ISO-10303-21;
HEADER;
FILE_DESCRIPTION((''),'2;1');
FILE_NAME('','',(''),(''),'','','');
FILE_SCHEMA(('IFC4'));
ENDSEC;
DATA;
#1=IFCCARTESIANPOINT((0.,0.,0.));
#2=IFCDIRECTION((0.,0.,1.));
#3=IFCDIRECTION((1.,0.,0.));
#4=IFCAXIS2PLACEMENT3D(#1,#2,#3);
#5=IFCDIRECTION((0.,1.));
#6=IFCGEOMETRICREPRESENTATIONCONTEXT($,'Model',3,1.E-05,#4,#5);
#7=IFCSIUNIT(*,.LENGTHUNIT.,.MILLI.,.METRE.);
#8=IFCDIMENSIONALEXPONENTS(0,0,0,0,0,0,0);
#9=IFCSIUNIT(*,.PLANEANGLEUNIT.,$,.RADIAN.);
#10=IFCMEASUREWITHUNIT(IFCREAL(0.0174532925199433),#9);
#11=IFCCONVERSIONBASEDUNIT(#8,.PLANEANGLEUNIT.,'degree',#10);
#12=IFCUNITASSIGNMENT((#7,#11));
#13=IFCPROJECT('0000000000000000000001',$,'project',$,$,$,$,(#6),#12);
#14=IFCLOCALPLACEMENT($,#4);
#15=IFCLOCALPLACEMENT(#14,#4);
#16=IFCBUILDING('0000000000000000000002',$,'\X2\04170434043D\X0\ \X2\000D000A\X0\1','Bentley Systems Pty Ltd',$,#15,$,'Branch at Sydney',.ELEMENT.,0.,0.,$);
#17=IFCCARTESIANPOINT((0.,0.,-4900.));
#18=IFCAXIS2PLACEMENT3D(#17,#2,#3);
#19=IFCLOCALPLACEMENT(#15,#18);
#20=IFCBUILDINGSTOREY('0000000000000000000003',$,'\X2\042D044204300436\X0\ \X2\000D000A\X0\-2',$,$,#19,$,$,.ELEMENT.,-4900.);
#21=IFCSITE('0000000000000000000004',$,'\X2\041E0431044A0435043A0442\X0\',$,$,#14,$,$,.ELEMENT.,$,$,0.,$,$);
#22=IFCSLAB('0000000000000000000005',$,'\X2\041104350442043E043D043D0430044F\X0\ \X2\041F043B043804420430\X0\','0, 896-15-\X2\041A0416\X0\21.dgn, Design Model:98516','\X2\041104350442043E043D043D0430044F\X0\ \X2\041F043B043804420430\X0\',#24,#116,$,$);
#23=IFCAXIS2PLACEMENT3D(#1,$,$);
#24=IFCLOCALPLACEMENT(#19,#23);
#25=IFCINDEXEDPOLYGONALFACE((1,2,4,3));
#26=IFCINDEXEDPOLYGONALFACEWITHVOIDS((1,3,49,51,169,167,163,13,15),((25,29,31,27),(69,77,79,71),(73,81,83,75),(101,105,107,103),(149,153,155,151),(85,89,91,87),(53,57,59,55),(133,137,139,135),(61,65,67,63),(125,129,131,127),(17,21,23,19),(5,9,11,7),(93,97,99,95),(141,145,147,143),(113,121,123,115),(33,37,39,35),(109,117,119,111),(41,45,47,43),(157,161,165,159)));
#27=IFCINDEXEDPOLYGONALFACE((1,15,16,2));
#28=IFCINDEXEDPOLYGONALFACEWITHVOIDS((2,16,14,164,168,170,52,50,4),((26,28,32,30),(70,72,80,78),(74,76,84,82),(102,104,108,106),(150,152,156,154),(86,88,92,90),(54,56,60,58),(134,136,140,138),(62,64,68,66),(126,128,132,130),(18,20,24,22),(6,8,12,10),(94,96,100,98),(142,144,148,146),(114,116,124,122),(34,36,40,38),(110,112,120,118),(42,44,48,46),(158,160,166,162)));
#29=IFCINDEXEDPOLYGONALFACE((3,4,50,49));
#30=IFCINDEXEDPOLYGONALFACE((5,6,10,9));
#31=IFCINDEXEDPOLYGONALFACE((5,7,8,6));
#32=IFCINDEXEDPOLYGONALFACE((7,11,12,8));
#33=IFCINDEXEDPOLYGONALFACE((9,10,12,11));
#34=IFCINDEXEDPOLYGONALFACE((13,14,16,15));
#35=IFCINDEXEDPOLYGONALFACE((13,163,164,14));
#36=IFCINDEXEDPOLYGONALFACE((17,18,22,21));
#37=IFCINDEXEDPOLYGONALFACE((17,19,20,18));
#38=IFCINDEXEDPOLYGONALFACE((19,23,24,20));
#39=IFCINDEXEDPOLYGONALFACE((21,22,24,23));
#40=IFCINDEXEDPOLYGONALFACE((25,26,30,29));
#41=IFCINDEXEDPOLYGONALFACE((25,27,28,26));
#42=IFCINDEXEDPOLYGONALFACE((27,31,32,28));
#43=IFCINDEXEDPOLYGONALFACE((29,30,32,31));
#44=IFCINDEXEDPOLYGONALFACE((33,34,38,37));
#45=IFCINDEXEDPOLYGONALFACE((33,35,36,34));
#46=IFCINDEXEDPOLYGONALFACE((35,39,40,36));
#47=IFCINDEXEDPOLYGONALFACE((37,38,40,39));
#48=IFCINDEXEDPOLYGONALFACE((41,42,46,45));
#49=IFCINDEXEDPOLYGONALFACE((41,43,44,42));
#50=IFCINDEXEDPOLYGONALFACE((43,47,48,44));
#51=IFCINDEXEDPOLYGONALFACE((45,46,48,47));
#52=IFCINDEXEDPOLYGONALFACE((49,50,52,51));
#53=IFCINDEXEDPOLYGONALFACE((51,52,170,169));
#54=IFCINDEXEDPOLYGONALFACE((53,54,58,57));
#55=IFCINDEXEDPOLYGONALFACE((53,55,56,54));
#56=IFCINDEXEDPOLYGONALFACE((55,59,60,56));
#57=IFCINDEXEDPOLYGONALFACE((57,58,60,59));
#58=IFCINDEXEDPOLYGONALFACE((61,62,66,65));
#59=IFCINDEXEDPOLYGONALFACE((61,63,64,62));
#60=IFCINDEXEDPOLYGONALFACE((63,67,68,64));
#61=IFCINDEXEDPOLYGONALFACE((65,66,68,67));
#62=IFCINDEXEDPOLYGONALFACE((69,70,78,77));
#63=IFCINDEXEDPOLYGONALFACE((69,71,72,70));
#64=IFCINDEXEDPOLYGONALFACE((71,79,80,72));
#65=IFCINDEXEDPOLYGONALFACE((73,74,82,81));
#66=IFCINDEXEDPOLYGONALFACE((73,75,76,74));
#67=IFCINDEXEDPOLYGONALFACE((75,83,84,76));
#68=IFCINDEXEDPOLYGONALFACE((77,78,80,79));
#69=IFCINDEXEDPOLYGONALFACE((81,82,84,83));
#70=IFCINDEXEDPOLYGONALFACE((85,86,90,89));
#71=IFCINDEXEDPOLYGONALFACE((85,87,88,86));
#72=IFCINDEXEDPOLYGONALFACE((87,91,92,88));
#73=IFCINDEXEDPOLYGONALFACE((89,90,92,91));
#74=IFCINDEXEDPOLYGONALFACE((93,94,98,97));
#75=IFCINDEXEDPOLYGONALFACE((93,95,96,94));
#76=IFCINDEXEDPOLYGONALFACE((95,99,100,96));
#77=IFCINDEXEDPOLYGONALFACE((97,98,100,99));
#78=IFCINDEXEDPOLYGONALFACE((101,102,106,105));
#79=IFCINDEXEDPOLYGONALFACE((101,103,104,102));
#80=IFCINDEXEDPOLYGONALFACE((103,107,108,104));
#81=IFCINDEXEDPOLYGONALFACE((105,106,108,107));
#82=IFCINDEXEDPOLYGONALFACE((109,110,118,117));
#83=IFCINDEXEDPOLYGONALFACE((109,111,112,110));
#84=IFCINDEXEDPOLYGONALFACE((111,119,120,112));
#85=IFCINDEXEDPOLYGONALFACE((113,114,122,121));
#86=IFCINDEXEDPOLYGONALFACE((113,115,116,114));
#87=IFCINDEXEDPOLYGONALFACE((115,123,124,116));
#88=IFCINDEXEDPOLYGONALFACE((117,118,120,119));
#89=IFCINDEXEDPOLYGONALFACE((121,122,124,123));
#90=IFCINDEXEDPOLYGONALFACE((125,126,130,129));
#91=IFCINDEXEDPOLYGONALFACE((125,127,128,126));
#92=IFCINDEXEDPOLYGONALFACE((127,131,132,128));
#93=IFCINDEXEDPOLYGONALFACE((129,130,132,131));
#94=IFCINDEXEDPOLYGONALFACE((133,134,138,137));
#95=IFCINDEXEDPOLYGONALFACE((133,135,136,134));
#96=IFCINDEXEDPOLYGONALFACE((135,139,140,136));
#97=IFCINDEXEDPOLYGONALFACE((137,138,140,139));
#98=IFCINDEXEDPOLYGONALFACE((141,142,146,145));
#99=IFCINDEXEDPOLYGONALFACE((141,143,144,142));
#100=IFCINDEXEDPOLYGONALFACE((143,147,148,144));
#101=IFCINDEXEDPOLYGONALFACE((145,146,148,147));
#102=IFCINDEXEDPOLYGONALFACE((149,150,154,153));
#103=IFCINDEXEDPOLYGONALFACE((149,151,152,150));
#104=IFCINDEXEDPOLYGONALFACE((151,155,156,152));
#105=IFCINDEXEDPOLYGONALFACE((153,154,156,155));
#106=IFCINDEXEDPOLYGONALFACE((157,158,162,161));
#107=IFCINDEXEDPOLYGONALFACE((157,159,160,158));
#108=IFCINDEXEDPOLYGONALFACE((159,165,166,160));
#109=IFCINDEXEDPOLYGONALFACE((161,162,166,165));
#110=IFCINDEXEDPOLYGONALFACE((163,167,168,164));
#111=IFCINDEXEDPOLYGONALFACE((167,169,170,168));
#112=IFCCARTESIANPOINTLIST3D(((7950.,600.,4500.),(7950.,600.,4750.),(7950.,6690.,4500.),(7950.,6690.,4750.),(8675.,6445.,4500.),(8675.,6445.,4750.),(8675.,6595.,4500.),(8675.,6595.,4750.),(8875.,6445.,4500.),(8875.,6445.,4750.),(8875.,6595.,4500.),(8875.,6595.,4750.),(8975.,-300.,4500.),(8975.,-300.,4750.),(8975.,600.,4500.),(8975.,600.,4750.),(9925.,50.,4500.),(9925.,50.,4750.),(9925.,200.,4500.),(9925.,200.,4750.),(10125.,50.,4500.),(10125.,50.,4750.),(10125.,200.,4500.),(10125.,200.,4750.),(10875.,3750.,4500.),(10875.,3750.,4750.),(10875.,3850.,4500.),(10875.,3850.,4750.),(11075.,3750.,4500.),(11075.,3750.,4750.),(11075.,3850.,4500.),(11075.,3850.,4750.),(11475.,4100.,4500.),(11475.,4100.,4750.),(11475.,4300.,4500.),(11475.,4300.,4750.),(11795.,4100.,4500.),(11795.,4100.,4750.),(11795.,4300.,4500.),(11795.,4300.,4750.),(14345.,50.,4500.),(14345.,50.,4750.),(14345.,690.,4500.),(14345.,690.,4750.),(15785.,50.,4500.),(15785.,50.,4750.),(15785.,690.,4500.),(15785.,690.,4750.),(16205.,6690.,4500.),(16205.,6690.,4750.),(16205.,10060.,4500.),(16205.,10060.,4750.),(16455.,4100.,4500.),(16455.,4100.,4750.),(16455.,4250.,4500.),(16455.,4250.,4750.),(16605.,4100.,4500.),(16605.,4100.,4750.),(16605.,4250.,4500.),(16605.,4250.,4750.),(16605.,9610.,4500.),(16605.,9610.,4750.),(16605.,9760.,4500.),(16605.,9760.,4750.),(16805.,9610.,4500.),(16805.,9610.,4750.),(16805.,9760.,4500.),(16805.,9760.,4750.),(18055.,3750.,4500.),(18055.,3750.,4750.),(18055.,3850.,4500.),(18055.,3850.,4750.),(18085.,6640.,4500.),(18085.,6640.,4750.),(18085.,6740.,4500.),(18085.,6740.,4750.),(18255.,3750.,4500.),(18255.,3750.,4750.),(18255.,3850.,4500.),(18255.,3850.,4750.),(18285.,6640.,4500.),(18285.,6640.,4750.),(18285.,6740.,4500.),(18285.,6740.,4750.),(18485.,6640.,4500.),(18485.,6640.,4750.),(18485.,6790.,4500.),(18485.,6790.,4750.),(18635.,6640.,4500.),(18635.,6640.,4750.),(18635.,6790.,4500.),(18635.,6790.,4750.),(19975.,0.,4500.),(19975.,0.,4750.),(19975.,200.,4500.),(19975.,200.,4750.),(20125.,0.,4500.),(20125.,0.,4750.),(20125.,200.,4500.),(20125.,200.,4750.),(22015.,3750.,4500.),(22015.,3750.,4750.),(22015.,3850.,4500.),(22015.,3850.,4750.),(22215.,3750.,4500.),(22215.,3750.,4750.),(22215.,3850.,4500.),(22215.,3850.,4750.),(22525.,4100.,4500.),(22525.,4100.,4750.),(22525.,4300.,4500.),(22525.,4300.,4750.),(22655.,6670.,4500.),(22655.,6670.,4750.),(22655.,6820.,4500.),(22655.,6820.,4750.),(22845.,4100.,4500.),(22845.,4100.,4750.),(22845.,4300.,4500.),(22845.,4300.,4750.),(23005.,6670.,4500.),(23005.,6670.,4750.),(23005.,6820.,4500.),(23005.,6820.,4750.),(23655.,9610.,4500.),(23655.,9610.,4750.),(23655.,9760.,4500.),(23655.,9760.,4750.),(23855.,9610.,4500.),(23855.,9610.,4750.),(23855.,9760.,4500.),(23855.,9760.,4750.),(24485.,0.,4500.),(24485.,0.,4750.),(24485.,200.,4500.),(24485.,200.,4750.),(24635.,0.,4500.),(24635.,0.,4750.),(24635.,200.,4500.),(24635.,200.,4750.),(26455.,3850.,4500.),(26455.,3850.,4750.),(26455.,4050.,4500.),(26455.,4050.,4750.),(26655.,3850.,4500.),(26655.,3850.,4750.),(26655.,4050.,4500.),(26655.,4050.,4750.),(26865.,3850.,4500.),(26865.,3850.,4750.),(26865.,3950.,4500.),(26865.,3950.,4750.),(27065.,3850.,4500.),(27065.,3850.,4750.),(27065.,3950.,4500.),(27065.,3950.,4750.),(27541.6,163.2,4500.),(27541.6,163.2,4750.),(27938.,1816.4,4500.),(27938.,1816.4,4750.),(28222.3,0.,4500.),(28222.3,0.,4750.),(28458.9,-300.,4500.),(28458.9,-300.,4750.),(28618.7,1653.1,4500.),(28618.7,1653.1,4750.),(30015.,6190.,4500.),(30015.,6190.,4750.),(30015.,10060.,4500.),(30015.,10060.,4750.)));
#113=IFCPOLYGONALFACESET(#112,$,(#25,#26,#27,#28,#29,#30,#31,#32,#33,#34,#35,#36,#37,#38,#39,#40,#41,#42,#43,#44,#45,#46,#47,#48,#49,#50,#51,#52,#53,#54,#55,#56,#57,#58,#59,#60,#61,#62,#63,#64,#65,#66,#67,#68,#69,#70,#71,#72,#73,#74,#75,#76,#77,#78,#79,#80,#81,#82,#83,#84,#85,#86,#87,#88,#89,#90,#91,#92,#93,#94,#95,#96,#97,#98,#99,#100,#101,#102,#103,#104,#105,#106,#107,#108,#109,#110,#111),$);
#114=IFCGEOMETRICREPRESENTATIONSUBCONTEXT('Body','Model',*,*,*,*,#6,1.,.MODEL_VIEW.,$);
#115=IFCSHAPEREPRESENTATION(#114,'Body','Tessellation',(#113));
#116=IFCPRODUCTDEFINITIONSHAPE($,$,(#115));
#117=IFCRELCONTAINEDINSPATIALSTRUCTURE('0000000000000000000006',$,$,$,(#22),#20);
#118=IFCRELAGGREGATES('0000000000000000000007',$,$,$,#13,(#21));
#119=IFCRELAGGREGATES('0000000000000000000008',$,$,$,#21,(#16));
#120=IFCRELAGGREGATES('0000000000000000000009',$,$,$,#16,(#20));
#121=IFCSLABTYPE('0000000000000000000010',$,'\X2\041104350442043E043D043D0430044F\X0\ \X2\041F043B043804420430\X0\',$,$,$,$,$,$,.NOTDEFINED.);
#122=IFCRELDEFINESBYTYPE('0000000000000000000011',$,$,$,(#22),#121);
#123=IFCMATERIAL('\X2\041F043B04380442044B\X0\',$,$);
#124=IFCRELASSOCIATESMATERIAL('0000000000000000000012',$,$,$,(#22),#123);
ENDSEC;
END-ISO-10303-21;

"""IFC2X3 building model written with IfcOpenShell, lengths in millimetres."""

from ifc_helpers import new_model, entity, si_unit, converted_unit, direction, frame, frame_2d, origin_with_axes, place, context, subcontext, project, spatial, polyline, rectangle, outline, extrude, material, type_object, element, save


model = new_model("IFC2X3")

# Units and contexts
model_context = context("Model", 3, precision=1e-05, world=origin_with_axes(), true_north=direction((0.0, 1.0)))
body_context = subcontext(model_context, "Body", "Model", "MODEL_VIEW", scale=1.0)
ifc_project = project(units=[si_unit("LENGTHUNIT", "METRE", prefix="MILLI"), converted_unit("PLANEANGLEUNIT", "degree", entity("IfcReal", 0.0174532925199433), si_unit("PLANEANGLEUNIT", "RADIAN"), dimensions=[0, 0, 0, 0, 0, 0, 0])], contexts=[model_context])

# Site, building, storey
site_placement = place(None, origin_with_axes())
site = spatial("IfcSite", under=ifc_project, at=site_placement, Name="Объект", CompositionType="ELEMENT", RefElevation=0.0)
building_placement = place(site_placement, origin_with_axes())
building = spatial("IfcBuilding", under=site, at=building_placement, Name="Здн \r\n1", Description="Bentley Systems Pty Ltd", LongName="Branch at Sydney", CompositionType="ELEMENT", ElevationOfRefHeight=0.0, ElevationOfTerrain=0.0)
storey_placement = place(building_placement, frame((0.0, 0.0, -4900.0), z_axis=(0.0, 0.0, 1.0), x_axis=(1.0, 0.0, 0.0)))
storey = spatial("IfcBuildingStorey", under=building, at=storey_placement, Name="Этаж \r\n-2", CompositionType="ELEMENT", Elevation=-4900.0)

# Shared definitions
ifc_material_1 = material(Name="Плиты")
slab_type = type_object("IfcSlabType", Name="Бетонная Плита", PredefinedType="NOTDEFINED")

# Slab, openings
slab_1_placement = place(storey_placement, frame((7950.0, 6690.0, 4750.0), z_axis=(0.0, 0.0, -1.0), x_axis=(1.0, 0.0, 0.0)))
slab_1 = element("IfcSlab", 1, at=slab_1_placement, inside=storey, type_object=slab_type, material=ifc_material_1, Name="Бетонная Плита", Description="0, 896-15-КЖ21.dgn, Design Model:98516", ObjectType="Бетонная Плита", context=body_context, shape_type="SweptSolid", body=[
    extrude(outline(polyline([(0.0, 0.0), (8255.0, 0.0), (8255.0, -3370.0), (22065.0, -3370.0), (22065.0, 500.0), (20508.9, 6990.0), (1025.0, 6990.0), (1025.0, 6090.0), (0.0, 6090.0), (0.0, 0.0)])), origin_with_axes(), (0.0, 0.0, 1.0), 250.0),
])
opening_1_placement = place(slab_1_placement, frame((6395.0, 6000.0, 0.0), z_axis=(0.0, 0.0, 1.0), x_axis=(1.0, 0.0, 0.0)))
element("IfcOpeningElement", 2, at=opening_1_placement, cuts=slab_1, ObjectType="Opening", context=body_context, shape_type="SweptSolid", body=[
    extrude(rectangle(XDim=1440.0, YDim=640.0, at=frame_2d((-720.0, 320.0), x_axis=(1.0, 0.0))), frame((0.0, 0.0, 375.0), z_axis=(0.0, 0.0, -1.0), x_axis=(-1.0, 0.0, 0.0)), (0.0, 0.0, 1.0), 750.0),
])
opening_2_placement = place(slab_1_placement, frame((1975.0, 6490.0, 0.0), z_axis=(0.0, 0.0, 1.0), x_axis=(1.0, 0.0, 0.0)))
element("IfcOpeningElement", 3, at=opening_2_placement, cuts=slab_1, ObjectType="Opening", context=body_context, shape_type="SweptSolid", body=[
    extrude(rectangle(XDim=200.0, YDim=150.0, at=frame_2d((-100.0, 75.0), x_axis=(1.0, 0.0))), frame((0.0, 0.0, 375.0), z_axis=(0.0, 0.0, -1.0), x_axis=(-1.0, 0.0, 0.0)), (0.0, 0.0, 1.0), 750.0),
])
opening_3_placement = place(slab_1_placement, frame((725.0, 95.0, 0.0), z_axis=(0.0, 0.0, 1.0), x_axis=(1.0, 0.0, 0.0)))
element("IfcOpeningElement", 4, at=opening_3_placement, cuts=slab_1, ObjectType="Opening", context=body_context, shape_type="SweptSolid", body=[
    extrude(rectangle(XDim=200.0, YDim=150.0, at=frame_2d((-100.0, 75.0), x_axis=(1.0, 0.0))), frame((0.0, 0.0, 375.0), z_axis=(0.0, 0.0, -1.0), x_axis=(-1.0, 0.0, 0.0)), (0.0, 0.0, 1.0), 750.0),
])
opening_4_placement = place(slab_1_placement, frame((2925.0, 2840.0, 0.0), z_axis=(0.0, 0.0, 1.0), x_axis=(1.0, 0.0, 0.0)))
element("IfcOpeningElement", 5, at=opening_4_placement, cuts=slab_1, ObjectType="Opening", context=body_context, shape_type="SweptSolid", body=[
    extrude(rectangle(XDim=200.0, YDim=100.0, at=frame_2d((-100.0, 50.0), x_axis=(1.0, 0.0))), frame((0.0, 0.0, 375.0), z_axis=(0.0, 0.0, -1.0), x_axis=(-1.0, 0.0, 0.0)), (0.0, 0.0, 1.0), 750.0),
])
opening_5_placement = place(slab_1_placement, frame((3525.0, 2390.0, 0.0), z_axis=(0.0, 0.0, 1.0), x_axis=(1.0, 0.0, 0.0)))
element("IfcOpeningElement", 6, at=opening_5_placement, cuts=slab_1, ObjectType="Opening", context=body_context, shape_type="SweptSolid", body=[
    extrude(rectangle(XDim=320.0, YDim=200.0, at=frame_2d((-160.0, 100.0), x_axis=(1.0, 0.0))), frame((0.0, 0.0, 375.0), z_axis=(0.0, 0.0, -1.0), x_axis=(-1.0, 0.0, 0.0)), (0.0, 0.0, 1.0), 750.0),
])
opening_6_placement = place(slab_1_placement, frame((12025.0, 6490.0, 0.0), z_axis=(0.0, 0.0, 1.0), x_axis=(1.0, 0.0, 0.0)))
element("IfcOpeningElement", 7, at=opening_6_placement, cuts=slab_1, ObjectType="Opening", context=body_context, shape_type="SweptSolid", body=[
    extrude(rectangle(XDim=150.0, YDim=200.0, at=frame_2d((-75.0, 100.0), x_axis=(1.0, 0.0))), frame((0.0, 0.0, 375.0), z_axis=(0.0, 0.0, -1.0), x_axis=(-1.0, 0.0, 0.0)), (0.0, 0.0, 1.0), 750.0),
])
opening_7_placement = place(slab_1_placement, frame((16535.0, 6490.0, 0.0), z_axis=(0.0, 0.0, 1.0), x_axis=(1.0, 0.0, 0.0)))
element("IfcOpeningElement", 8, at=opening_7_placement, cuts=slab_1, ObjectType="Opening", context=body_context, shape_type="SweptSolid", body=[
    extrude(rectangle(XDim=150.0, YDim=200.0, at=frame_2d((-75.0, 100.0), x_axis=(1.0, 0.0))), frame((0.0, 0.0, 375.0), z_axis=(0.0, 0.0, -1.0), x_axis=(-1.0, 0.0, 0.0)), (0.0, 0.0, 1.0), 750.0),
])
opening_8_placement = place(slab_1_placement, frame((19591.6, 4873.6, 0.0), z_axis=(0.0, 0.0, 1.0), x_axis=(1.0, 0.0, 0.0)))
element("IfcOpeningElement", 9, at=opening_8_placement, cuts=slab_1, ObjectType="Opening", context=body_context, shape_type="SweptSolid", body=[
    extrude(rectangle(XDim=1700.0, YDim=700.0, at=frame_2d((-538.5, 908.2), x_axis=(0.233165, 0.972437))), frame((0.0, 0.0, 375.0), z_axis=(0.0, 0.0, -1.0), x_axis=(-1.0, 0.0, 0.0)), (0.0, 0.0, 1.0), 750.0),
])
opening_9_placement = place(slab_1_placement, frame((8655.0, -3070.0, 0.0), z_axis=(0.0, 0.0, 1.0), x_axis=(1.0, 0.0, 0.0)))
element("IfcOpeningElement", 10, at=opening_9_placement, cuts=slab_1, ObjectType="Opening", context=body_context, shape_type="SweptSolid", body=[
    extrude(rectangle(XDim=200.0, YDim=150.0, at=frame_2d((-100.0, 75.0), x_axis=(1.0, 0.0))), frame((0.0, 0.0, 375.0), z_axis=(0.0, 0.0, -1.0), x_axis=(-1.0, 0.0, 0.0)), (0.0, 0.0, 1.0), 750.0),
])
opening_10_placement = place(slab_1_placement, frame((15705.0, -3070.0, 0.0), z_axis=(0.0, 0.0, 1.0), x_axis=(1.0, 0.0, 0.0)))
element("IfcOpeningElement", 11, at=opening_10_placement, cuts=slab_1, ObjectType="Opening", context=body_context, shape_type="SweptSolid", body=[
    extrude(rectangle(XDim=200.0, YDim=150.0, at=frame_2d((-100.0, 75.0), x_axis=(1.0, 0.0))), frame((0.0, 0.0, 375.0), z_axis=(0.0, 0.0, -1.0), x_axis=(-1.0, 0.0, 0.0)), (0.0, 0.0, 1.0), 750.0),
])
opening_11_placement = place(slab_1_placement, frame((10135.0, -50.0, 0.0), z_axis=(0.0, 0.0, 1.0), x_axis=(1.0, 0.0, 0.0)))
element("IfcOpeningElement", 12, at=opening_11_placement, cuts=slab_1, ObjectType="Opening", context=body_context, shape_type="SweptSolid", body=[
    extrude(rectangle(XDim=200.0, YDim=100.0, at=frame_2d((-100.0, 50.0), x_axis=(1.0, 0.0))), frame((0.0, 0.0, 375.0), z_axis=(0.0, 0.0, -1.0), x_axis=(-1.0, 0.0, 0.0)), (0.0, 0.0, 1.0), 750.0),
])
opening_12_placement = place(slab_1_placement, frame((10535.0, -100.0, 0.0), z_axis=(0.0, 0.0, 1.0), x_axis=(1.0, 0.0, 0.0)))
element("IfcOpeningElement", 13, at=opening_12_placement, cuts=slab_1, ObjectType="Opening", context=body_context, shape_type="SweptSolid", body=[
    extrude(rectangle(XDim=150.0, YDim=150.0, at=frame_2d((-75.0, 75.0), x_axis=(1.0, 0.0))), frame((0.0, 0.0, 375.0), z_axis=(0.0, 0.0, -1.0), x_axis=(-1.0, 0.0, 0.0)), (0.0, 0.0, 1.0), 750.0),
])
opening_13_placement = place(slab_1_placement, frame((14705.0, -130.0, 0.0), z_axis=(0.0, 0.0, 1.0), x_axis=(1.0, 0.0, 0.0)))
element("IfcOpeningElement", 14, at=opening_13_placement, cuts=slab_1, ObjectType="Opening", context=body_context, shape_type="SweptSolid", body=[
    extrude(rectangle(XDim=350.0, YDim=150.0, at=frame_2d((-175.0, 75.0), x_axis=(1.0, 0.0))), frame((0.0, 0.0, 375.0), z_axis=(0.0, 0.0, -1.0), x_axis=(-1.0, 0.0, 0.0)), (0.0, 0.0, 1.0), 750.0),
])
opening_14_placement = place(slab_1_placement, frame((8505.0, 2440.0, 0.0), z_axis=(0.0, 0.0, 1.0), x_axis=(1.0, 0.0, 0.0)))
element("IfcOpeningElement", 15, at=opening_14_placement, cuts=slab_1, ObjectType="Opening", context=body_context, shape_type="SweptSolid", body=[
    extrude(rectangle(XDim=150.0, YDim=150.0, at=frame_2d((-75.0, 75.0), x_axis=(1.0, 0.0))), frame((0.0, 0.0, 375.0), z_axis=(0.0, 0.0, -1.0), x_axis=(-1.0, 0.0, 0.0)), (0.0, 0.0, 1.0), 750.0),
])
opening_15_placement = place(slab_1_placement, frame((10105.0, 2840.0, 0.0), z_axis=(0.0, 0.0, 1.0), x_axis=(1.0, 0.0, 0.0)))
element("IfcOpeningElement", 16, at=opening_15_placement, cuts=slab_1, ObjectType="Opening", context=body_context, shape_type="SweptSolid", body=[
    extrude(rectangle(XDim=200.0, YDim=100.0, at=frame_2d((-100.0, 50.0), x_axis=(1.0, 0.0))), frame((0.0, 0.0, 375.0), z_axis=(0.0, 0.0, -1.0), x_axis=(-1.0, 0.0, 0.0)), (0.0, 0.0, 1.0), 750.0),
])
opening_16_placement = place(slab_1_placement, frame((14065.0, 2840.0, 0.0), z_axis=(0.0, 0.0, 1.0), x_axis=(1.0, 0.0, 0.0)))
element("IfcOpeningElement", 17, at=opening_16_placement, cuts=slab_1, ObjectType="Opening", context=body_context, shape_type="SweptSolid", body=[
    extrude(rectangle(XDim=200.0, YDim=100.0, at=frame_2d((-100.0, 50.0), x_axis=(1.0, 0.0))), frame((0.0, 0.0, 375.0), z_axis=(0.0, 0.0, -1.0), x_axis=(-1.0, 0.0, 0.0)), (0.0, 0.0, 1.0), 750.0),
])
opening_17_placement = place(slab_1_placement, frame((14575.0, 2390.0, 0.0), z_axis=(0.0, 0.0, 1.0), x_axis=(1.0, 0.0, 0.0)))
element("IfcOpeningElement", 18, at=opening_17_placement, cuts=slab_1, ObjectType="Opening", context=body_context, shape_type="SweptSolid", body=[
    extrude(rectangle(XDim=320.0, YDim=200.0, at=frame_2d((-160.0, 100.0), x_axis=(1.0, 0.0))), frame((0.0, 0.0, 375.0), z_axis=(0.0, 0.0, -1.0), x_axis=(-1.0, 0.0, 0.0)), (0.0, 0.0, 1.0), 750.0),
])
opening_18_placement = place(slab_1_placement, frame((18505.0, 2640.0, 0.0), z_axis=(0.0, 0.0, 1.0), x_axis=(1.0, 0.0, 0.0)))
element("IfcOpeningElement", 19, at=opening_18_placement, cuts=slab_1, ObjectType="Opening", context=body_context, shape_type="SweptSolid", body=[
    extrude(rectangle(XDim=200.0, YDim=200.0, at=frame_2d((-100.0, 100.0), x_axis=(1.0, 0.0))), frame((0.0, 0.0, 375.0), z_axis=(0.0, 0.0, -1.0), x_axis=(-1.0, 0.0, 0.0)), (0.0, 0.0, 1.0), 750.0),
])
opening_19_placement = place(slab_1_placement, frame((18915.0, 2740.0, 0.0), z_axis=(0.0, 0.0, 1.0), x_axis=(1.0, 0.0, 0.0)))
element("IfcOpeningElement", 20, at=opening_19_placement, cuts=slab_1, ObjectType="Opening", context=body_context, shape_type="SweptSolid", body=[
    extrude(rectangle(XDim=200.0, YDim=100.0, at=frame_2d((-100.0, 50.0), x_axis=(1.0, 0.0))), frame((0.0, 0.0, 375.0), z_axis=(0.0, 0.0, -1.0), x_axis=(-1.0, 0.0, 0.0)), (0.0, 0.0, 1.0), 750.0),
])

save(model, "model.ifc")
